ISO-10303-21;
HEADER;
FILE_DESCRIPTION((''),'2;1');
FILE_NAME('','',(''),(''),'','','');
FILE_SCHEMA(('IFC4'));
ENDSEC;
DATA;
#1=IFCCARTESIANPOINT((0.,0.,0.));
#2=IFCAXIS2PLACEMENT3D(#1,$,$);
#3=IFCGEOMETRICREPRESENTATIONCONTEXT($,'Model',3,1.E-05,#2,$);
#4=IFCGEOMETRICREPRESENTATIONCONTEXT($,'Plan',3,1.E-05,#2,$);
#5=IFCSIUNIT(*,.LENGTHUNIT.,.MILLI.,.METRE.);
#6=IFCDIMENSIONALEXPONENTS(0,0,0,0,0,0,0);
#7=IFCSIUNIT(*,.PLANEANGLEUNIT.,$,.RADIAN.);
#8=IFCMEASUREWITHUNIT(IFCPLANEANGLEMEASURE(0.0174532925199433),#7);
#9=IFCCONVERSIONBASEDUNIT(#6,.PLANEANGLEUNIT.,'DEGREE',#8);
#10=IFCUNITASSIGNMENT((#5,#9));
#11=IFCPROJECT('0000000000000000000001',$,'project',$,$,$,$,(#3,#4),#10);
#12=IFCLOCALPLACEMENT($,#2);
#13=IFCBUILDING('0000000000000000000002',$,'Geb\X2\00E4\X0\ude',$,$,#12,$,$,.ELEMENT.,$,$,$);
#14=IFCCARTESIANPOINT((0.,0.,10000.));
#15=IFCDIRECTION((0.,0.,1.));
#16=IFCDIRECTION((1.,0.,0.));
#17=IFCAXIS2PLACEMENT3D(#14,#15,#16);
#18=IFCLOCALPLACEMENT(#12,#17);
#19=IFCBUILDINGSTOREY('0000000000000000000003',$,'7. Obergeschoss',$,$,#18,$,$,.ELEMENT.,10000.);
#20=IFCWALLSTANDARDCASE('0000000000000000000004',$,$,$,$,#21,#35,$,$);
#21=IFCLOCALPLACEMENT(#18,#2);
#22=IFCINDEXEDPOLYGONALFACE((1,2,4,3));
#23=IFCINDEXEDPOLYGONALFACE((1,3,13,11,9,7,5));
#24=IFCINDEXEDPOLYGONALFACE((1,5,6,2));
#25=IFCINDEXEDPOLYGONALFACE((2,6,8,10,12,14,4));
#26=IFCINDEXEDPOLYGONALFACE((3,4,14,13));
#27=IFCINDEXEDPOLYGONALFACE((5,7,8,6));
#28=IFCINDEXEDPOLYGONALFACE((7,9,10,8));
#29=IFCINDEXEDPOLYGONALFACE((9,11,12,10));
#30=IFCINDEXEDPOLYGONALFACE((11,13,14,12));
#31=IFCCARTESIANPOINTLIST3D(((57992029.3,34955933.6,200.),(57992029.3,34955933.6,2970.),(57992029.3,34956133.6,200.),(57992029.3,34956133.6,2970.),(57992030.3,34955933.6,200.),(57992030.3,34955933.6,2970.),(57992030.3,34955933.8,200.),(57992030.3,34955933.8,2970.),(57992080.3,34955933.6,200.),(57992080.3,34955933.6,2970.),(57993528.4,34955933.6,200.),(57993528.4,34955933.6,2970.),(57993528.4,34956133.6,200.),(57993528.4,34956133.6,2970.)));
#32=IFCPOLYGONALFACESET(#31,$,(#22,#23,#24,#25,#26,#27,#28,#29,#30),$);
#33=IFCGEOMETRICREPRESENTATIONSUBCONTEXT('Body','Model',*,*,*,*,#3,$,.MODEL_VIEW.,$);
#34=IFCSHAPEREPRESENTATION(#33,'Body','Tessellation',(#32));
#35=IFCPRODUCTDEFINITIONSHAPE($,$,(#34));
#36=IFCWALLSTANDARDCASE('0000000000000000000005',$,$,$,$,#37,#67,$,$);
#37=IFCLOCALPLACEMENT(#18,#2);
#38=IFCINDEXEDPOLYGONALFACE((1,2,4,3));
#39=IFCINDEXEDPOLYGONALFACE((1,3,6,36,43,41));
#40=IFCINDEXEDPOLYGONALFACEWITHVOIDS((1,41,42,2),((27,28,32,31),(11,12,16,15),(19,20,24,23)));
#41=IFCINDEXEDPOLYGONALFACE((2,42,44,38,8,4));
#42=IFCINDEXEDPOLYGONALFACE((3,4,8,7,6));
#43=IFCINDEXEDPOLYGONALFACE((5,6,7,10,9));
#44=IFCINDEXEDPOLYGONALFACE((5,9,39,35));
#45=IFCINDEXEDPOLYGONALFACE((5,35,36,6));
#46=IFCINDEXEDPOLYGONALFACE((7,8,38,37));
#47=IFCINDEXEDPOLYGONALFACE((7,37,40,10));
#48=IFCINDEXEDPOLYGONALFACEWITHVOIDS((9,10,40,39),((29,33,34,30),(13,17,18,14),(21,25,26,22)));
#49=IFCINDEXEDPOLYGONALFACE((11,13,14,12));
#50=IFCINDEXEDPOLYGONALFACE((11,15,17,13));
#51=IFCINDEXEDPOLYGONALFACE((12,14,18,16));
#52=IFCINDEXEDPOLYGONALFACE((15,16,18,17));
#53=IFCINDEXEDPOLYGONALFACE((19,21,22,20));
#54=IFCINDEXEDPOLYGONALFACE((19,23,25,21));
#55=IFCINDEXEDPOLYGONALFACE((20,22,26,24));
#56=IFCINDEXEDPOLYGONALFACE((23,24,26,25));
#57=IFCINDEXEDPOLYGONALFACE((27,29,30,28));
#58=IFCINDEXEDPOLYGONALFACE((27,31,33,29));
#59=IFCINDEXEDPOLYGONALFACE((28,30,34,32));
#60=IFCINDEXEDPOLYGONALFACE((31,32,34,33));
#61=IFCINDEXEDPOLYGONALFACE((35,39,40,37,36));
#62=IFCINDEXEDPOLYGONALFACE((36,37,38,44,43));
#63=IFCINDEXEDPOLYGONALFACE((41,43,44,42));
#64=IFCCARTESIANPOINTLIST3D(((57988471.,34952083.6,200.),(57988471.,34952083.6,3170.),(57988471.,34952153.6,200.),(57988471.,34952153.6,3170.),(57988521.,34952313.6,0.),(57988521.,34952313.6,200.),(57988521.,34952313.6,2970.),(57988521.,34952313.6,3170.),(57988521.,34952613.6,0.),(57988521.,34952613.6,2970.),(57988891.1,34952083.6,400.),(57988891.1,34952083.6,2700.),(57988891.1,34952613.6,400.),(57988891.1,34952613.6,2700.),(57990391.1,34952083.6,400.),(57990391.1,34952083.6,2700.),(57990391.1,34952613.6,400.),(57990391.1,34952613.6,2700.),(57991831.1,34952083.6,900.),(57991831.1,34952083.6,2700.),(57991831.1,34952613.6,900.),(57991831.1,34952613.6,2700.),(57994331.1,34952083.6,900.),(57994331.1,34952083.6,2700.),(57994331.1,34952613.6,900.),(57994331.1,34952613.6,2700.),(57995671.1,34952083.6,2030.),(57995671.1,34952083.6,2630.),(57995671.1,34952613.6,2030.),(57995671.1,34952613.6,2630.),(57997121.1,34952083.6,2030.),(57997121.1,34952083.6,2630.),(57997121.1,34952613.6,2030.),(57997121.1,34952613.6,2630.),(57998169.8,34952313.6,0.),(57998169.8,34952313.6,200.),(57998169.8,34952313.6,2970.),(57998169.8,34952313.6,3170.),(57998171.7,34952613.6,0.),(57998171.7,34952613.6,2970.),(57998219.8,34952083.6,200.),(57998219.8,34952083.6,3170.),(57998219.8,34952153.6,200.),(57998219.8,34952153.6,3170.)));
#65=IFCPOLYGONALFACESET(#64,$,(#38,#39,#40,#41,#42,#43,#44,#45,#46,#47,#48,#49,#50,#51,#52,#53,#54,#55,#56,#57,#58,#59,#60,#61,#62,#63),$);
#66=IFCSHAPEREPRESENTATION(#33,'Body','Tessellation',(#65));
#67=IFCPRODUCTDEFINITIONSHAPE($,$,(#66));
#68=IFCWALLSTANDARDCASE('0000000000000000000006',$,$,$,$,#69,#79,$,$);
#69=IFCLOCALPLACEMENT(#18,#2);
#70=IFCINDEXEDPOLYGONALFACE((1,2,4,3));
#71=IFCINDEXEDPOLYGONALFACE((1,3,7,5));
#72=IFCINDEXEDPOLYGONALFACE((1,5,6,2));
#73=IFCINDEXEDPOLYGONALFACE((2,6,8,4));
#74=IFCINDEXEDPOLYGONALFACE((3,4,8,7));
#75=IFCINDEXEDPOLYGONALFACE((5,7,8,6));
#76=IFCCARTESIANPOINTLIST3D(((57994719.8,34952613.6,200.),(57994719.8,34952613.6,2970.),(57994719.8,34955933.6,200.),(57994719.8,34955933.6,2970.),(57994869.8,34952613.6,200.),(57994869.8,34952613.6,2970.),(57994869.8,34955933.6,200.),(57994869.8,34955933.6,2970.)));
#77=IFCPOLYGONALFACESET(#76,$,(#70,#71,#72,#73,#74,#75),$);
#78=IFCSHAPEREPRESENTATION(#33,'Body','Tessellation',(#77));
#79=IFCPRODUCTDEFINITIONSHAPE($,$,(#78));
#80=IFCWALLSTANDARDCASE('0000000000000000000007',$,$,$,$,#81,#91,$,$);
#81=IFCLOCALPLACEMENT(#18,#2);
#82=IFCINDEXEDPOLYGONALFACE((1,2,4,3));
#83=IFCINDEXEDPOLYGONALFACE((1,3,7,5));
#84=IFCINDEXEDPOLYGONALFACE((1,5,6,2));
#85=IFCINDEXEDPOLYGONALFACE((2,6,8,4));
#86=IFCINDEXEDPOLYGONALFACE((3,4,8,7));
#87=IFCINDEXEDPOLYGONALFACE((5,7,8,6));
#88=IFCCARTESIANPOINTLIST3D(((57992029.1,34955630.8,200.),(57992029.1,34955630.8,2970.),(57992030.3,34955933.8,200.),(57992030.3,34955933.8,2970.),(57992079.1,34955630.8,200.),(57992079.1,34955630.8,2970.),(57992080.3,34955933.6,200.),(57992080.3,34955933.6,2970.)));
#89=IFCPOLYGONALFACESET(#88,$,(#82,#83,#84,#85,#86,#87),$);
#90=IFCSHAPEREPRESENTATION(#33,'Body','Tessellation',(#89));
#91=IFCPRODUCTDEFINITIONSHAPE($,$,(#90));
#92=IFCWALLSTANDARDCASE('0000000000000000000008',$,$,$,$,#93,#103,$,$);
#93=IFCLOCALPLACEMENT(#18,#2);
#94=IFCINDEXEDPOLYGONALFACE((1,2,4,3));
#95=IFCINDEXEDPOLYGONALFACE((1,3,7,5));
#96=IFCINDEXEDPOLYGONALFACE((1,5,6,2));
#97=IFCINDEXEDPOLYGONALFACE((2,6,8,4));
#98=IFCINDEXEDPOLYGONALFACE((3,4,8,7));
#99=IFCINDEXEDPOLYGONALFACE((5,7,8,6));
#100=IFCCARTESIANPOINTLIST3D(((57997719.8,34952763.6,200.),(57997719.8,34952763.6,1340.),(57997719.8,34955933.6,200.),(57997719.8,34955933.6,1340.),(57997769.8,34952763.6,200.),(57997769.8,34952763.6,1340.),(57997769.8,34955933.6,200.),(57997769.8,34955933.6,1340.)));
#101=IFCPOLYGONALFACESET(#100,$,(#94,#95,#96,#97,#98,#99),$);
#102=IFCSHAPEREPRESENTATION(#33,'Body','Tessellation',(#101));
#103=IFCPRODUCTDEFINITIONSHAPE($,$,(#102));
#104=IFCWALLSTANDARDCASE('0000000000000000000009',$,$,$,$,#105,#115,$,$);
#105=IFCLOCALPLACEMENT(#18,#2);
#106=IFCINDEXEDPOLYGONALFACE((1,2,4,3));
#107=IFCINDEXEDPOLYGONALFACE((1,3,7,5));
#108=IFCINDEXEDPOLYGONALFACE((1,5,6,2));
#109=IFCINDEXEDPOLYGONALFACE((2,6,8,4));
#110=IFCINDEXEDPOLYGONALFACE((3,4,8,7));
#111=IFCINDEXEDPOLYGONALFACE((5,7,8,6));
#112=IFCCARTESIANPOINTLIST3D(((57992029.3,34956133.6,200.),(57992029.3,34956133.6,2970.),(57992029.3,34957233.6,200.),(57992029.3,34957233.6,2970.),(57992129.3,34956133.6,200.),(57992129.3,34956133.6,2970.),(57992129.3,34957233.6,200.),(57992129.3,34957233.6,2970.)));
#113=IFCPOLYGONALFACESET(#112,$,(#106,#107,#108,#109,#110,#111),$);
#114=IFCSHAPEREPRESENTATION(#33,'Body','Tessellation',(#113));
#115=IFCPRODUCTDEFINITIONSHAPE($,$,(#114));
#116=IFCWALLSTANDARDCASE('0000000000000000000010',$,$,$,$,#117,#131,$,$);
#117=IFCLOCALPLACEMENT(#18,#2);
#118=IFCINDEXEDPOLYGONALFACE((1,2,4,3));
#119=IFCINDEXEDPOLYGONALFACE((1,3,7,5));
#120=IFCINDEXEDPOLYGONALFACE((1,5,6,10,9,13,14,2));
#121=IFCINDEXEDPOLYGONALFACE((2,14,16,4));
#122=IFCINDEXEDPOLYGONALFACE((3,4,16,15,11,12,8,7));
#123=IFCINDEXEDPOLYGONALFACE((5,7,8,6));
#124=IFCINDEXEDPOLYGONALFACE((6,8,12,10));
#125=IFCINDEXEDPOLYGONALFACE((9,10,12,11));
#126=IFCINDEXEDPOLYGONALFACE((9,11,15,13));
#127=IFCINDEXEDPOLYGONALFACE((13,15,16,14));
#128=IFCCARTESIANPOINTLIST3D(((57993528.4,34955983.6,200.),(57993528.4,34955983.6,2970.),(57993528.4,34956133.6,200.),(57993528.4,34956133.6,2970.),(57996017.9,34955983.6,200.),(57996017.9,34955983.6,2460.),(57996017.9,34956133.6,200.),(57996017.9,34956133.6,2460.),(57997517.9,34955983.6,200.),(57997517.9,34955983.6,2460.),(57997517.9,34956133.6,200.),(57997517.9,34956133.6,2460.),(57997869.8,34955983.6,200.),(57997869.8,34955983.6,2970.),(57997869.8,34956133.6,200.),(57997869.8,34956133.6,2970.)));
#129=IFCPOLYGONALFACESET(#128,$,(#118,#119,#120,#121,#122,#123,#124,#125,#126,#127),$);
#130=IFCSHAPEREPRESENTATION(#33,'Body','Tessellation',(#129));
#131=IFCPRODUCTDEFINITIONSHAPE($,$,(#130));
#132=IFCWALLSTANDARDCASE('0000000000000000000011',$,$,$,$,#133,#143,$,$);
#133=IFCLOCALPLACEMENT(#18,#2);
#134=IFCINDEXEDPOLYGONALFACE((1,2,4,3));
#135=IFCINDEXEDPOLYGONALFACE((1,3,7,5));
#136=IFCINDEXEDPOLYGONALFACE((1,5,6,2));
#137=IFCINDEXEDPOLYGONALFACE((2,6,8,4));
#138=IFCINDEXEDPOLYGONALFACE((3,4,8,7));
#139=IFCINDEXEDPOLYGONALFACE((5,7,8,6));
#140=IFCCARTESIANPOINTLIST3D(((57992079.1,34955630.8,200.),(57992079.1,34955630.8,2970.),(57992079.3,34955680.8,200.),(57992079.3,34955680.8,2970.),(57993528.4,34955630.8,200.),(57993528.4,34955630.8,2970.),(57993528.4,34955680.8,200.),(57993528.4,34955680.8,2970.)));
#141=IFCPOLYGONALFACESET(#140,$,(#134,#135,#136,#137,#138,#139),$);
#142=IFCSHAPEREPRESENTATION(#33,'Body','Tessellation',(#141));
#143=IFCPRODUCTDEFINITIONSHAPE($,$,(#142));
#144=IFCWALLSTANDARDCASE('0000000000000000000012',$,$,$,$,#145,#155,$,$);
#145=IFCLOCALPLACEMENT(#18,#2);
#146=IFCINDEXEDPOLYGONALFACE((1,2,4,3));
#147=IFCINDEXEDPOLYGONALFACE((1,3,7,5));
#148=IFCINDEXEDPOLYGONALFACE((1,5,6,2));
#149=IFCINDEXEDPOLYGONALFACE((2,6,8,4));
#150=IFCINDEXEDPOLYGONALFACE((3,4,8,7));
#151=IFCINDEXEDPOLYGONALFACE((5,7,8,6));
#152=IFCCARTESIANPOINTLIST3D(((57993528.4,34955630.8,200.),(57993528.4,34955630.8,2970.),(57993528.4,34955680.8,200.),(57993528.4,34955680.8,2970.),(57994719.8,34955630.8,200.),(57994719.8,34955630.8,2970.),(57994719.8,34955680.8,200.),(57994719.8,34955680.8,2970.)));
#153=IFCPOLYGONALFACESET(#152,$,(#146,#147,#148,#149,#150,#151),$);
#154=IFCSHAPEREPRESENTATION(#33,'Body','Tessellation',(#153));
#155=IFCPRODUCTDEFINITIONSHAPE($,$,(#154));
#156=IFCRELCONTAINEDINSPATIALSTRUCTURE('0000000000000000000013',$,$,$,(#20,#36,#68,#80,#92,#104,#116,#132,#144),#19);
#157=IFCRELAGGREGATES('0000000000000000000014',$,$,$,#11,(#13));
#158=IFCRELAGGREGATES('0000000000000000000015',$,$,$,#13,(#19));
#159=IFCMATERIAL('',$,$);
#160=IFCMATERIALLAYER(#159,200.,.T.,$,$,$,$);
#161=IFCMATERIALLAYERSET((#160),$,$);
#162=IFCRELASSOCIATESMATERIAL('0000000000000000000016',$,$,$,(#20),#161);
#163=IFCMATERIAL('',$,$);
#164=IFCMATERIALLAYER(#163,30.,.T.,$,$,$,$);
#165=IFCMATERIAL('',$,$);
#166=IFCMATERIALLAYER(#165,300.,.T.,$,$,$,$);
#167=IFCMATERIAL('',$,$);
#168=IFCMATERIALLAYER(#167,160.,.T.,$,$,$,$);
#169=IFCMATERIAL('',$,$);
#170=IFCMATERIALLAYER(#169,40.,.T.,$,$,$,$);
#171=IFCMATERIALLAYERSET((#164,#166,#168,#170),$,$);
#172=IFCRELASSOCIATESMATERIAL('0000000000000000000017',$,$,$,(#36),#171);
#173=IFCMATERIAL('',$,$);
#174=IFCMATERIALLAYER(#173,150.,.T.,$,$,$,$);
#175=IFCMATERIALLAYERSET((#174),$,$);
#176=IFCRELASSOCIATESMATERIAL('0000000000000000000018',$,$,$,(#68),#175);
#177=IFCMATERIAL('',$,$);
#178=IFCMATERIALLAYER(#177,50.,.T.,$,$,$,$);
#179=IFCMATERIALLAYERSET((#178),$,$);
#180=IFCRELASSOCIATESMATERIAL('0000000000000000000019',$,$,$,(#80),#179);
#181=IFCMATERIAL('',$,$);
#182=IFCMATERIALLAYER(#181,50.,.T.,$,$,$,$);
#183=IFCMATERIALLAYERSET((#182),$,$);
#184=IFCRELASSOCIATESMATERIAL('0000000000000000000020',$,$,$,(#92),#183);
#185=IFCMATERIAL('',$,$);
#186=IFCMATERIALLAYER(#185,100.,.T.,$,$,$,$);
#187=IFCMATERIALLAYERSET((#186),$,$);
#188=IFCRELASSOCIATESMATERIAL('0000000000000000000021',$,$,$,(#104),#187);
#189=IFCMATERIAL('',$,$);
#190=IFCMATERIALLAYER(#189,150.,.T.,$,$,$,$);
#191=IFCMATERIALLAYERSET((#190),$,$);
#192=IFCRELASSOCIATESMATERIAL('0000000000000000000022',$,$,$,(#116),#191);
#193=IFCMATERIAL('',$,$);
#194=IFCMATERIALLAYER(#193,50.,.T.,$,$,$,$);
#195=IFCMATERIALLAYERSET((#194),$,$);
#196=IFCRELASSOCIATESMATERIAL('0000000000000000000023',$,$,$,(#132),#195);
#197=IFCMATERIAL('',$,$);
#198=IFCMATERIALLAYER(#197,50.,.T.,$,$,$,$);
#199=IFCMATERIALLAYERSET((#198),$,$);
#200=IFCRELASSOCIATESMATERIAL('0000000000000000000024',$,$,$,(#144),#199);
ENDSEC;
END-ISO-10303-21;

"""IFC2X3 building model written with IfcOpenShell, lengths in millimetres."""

from ifc_helpers import new_model, entity, si_unit, converted_unit, frame, frame_2d, origin, origin_with_axes, place, context, subcontext, project, spatial, polyline, rectangle, outline, extrude, clip, bounded_halfspace, material, layer, layer_set, layer_usage, element, save


model = new_model("IFC2X3")

# Units and contexts
model_context = context("Model", 3, precision=1e-05, world=origin())
plan_context = context("Plan", 3, precision=1e-05, world=origin())
body_context = subcontext(model_context, "Body", "Model", "MODEL_VIEW")
ifc_project = project(units=[si_unit("LENGTHUNIT", "METRE", prefix="MILLI"), converted_unit("PLANEANGLEUNIT", "DEGREE", entity("IfcPlaneAngleMeasure", 0.0174532925199433), si_unit("PLANEANGLEUNIT", "RADIAN"), dimensions=[0, 0, 0, 0, 0, 0, 0])], contexts=[model_context, plan_context])

# Building, storey
building_placement = place(None, origin())
building = spatial("IfcBuilding", under=ifc_project, at=building_placement, Name="Gebäude", CompositionType="ELEMENT")
storey_placement = place(building_placement, frame((0.0, 0.0, 10000.0), z_axis=(0.0, 0.0, 1.0), x_axis=(1.0, 0.0, 0.0)))
storey = spatial("IfcBuildingStorey", under=building, at=storey_placement, Name="7. Obergeschoss", CompositionType="ELEMENT", Elevation=10000.0)

# Wall
ifc_material_1 = material(Name="")
ifc_layer_1 = layer(ifc_material_1, 200.0, ventilated=True)
ifc_layer_set_1 = layer_set([ifc_layer_1])
ifc_layer_usage_1 = layer_usage(ifc_layer_set_1, "AXIS2", "POSITIVE", 0.0)
wall_1_placement = place(storey_placement, frame((57993528.4, 34956133.6, 200.0), z_axis=(0.0, 0.0, 1.0), x_axis=(-1.0, 0.0, 0.0)))
element("IfcWallStandardCase", 1, at=wall_1_placement, inside=storey, material=ifc_layer_usage_1, context=body_context, shape_type="SweptSolid", body=[
    extrude(outline(polyline([(0.0, 0.0), (1499.1, 0.0), (1499.1, 200.0), (1498.1, 200.0), (1498.1, 199.8), (1448.1, 200.0), (0.0, 200.0), (0.0, 0.0)])), origin_with_axes(), (0.0, 0.0, 1.0), 2770.0),
])

# Wall, openings
ifc_material_2 = material(Name="")
ifc_layer_2 = layer(ifc_material_2, 30.0, ventilated=True)
ifc_material_3 = material(Name="")
ifc_layer_3 = layer(ifc_material_3, 300.0, ventilated=True)
ifc_material_4 = material(Name="")
ifc_layer_4 = layer(ifc_material_4, 160.0, ventilated=True)
ifc_material_5 = material(Name="")
ifc_layer_5 = layer(ifc_material_5, 40.0, ventilated=True)
ifc_layer_set_2 = layer_set([ifc_layer_2, ifc_layer_3, ifc_layer_4, ifc_layer_5])
ifc_layer_usage_2 = layer_usage(ifc_layer_set_2, "AXIS2", "POSITIVE", 0.0)
wall_2_placement = place(storey_placement, frame((57998171.7, 34952613.6, 0.0), z_axis=(0.0, 0.0, 1.0), x_axis=(-1.0, 0.0, 0.0)))
wall_2 = element("IfcWallStandardCase", 2, at=wall_2_placement, inside=storey, material=ifc_layer_usage_2, context=body_context, shape_type="Clipping", body=[
    clip(clip(clip(clip(extrude(outline(polyline([(0.0, 0.0), (9650.7, 0.0), (9650.7, 300.0), (9700.7, 460.0), (9700.7, 530.0), (-48.1, 530.0), (-48.1, 460.0), (1.9, 300.0), (0.0, 0.0)])), origin_with_axes(), (0.0, 0.0, 1.0), 3170.0), bounded_halfspace(frame((1.9, 300.0, 0.0), z_axis=(0.0, 0.0, 1.0), x_axis=(1.0, 0.0, 0.0)), True, origin(), polyline([(1.9, 300.0), (0.0, 0.0), (9650.7, 0.0), (9650.7, 300.0), (1.9, 300.0)]))), bounded_halfspace(frame((0.0, 0.0, 2970.0), z_axis=(0.0, 0.0, -1.0), x_axis=(1.0, 0.0, 0.0)), True, origin(), polyline([(0.0, 0.0), (9650.7, 0.0), (9650.7, 300.0), (1.9, 300.0), (0.0, 0.0)]))), bounded_halfspace(frame((-48.1, 460.0, 200.0), z_axis=(0.0, 0.0, 1.0), x_axis=(1.0, 0.0, 0.0)), True, origin(), polyline([(-48.1, 460.0), (1.9, 300.0), (9650.7, 300.0), (9700.7, 460.0), (9700.7, 530.0), (-48.1, 530.0), (-48.1, 460.0)]))), bounded_halfspace(frame((1.9, 300.0, 3170.0), z_axis=(0.0, 0.0, -1.0), x_axis=(1.0, 0.0, 0.0)), True, origin(), polyline([(1.9, 300.0), (9650.7, 300.0), (9700.7, 460.0), (9700.7, 530.0), (-48.1, 530.0), (-48.1, 460.0), (1.9, 300.0)]))),
])
opening_1_placement = place(wall_2_placement, frame((3840.6, 0.0, 900.0), z_axis=(0.0, 1.0, 0.0), x_axis=(0.0, 0.0, 1.0)))
element("IfcOpeningElement", 3, at=opening_1_placement, cuts=wall_2, ObjectType="Opening", context=body_context, shape_type="SweptSolid", body=[
    extrude(rectangle(XDim=1800.0, YDim=2500.0, at=frame_2d((900.0, 1250.0), x_axis=(1.0, 0.0))), origin_with_axes(), (0.0, 0.0, 1.0), 530.0),
])
opening_2_placement = place(wall_2_placement, frame((7780.6, 0.0, 400.0), z_axis=(0.0, 1.0, 0.0), x_axis=(0.0, 0.0, 1.0)))
element("IfcOpeningElement", 4, at=opening_2_placement, cuts=wall_2, ObjectType="Opening", context=body_context, shape_type="SweptSolid", body=[
    extrude(rectangle(XDim=2300.0, YDim=1500.0, at=frame_2d((1150.0, 750.0), x_axis=(1.0, 0.0))), origin_with_axes(), (0.0, 0.0, 1.0), 530.0),
])
opening_3_placement = place(wall_2_placement, frame((1050.6, 0.0, 2030.0), z_axis=(0.0, 1.0, 0.0), x_axis=(0.0, 0.0, 1.0)))
element("IfcOpeningElement", 5, at=opening_3_placement, cuts=wall_2, ObjectType="Opening", context=body_context, shape_type="SweptSolid", body=[
    extrude(rectangle(XDim=600.0, YDim=1450.0, at=frame_2d((300.0, 725.0), x_axis=(1.0, 0.0))), origin_with_axes(), (0.0, 0.0, 1.0), 530.0),
])

# Walls
ifc_material_6 = material(Name="")
ifc_layer_6 = layer(ifc_material_6, 150.0, ventilated=True)
ifc_layer_set_3 = layer_set([ifc_layer_6])
ifc_layer_usage_3 = layer_usage(ifc_layer_set_3, "AXIS2", "POSITIVE", 0.0)
wall_3_placement = place(storey_placement, frame((57994869.8, 34952613.6, 200.0), z_axis=(0.0, 0.0, 1.0), x_axis=(0.0, 1.0, 0.0)))
element("IfcWallStandardCase", 6, at=wall_3_placement, inside=storey, material=ifc_layer_usage_3, context=body_context, shape_type="SweptSolid", body=[
    extrude(rectangle(XDim=3319.9, YDim=150.0, at=frame_2d((1660.0, 75.0), x_axis=(1.0, 0.0))), origin_with_axes(), (0.0, 0.0, 1.0), 2770.0),
])
ifc_material_7 = material(Name="")
ifc_layer_7 = layer(ifc_material_7, 50.0, ventilated=True)
ifc_layer_set_4 = layer_set([ifc_layer_7])
ifc_layer_usage_4 = layer_usage(ifc_layer_set_4, "AXIS2", "POSITIVE", 0.0)
wall_4_placement = place(storey_placement, frame((57992079.1, 34955630.8, 200.0), z_axis=(0.0, 0.0, 1.0), x_axis=(0.003955, 0.999992, 0.0)))
element("IfcWallStandardCase", 7, at=wall_4_placement, inside=storey, material=ifc_layer_usage_4, context=body_context, shape_type="SweptSolid", body=[
    extrude(outline(polyline([(0.0, 0.0), (302.8, 0.0), (302.8, 50.0), (-0.2, 50.0), (0.0, 0.0)])), origin_with_axes(), (0.0, 0.0, 1.0), 2770.0),
])
ifc_material_8 = material(Name="")
ifc_layer_8 = layer(ifc_material_8, 50.0, ventilated=True)
ifc_layer_set_5 = layer_set([ifc_layer_8])
ifc_layer_usage_5 = layer_usage(ifc_layer_set_5, "AXIS2", "POSITIVE", 0.0)
wall_5_placement = place(storey_placement, frame((57997719.8, 34955933.6, 200.0), z_axis=(0.0, 0.0, 1.0), x_axis=(0.0, -1.0, 0.0)))
element("IfcWallStandardCase", 8, at=wall_5_placement, inside=storey, material=ifc_layer_usage_5, context=body_context, shape_type="SweptSolid", body=[
    extrude(rectangle(XDim=3169.9, YDim=50.0, at=frame_2d((1585.0, 25.0), x_axis=(1.0, 0.0))), origin_with_axes(), (0.0, 0.0, 1.0), 1140.0),
])
ifc_material_9 = material(Name="")
ifc_layer_9 = layer(ifc_material_9, 100.0, ventilated=True)
ifc_layer_set_6 = layer_set([ifc_layer_9])
ifc_layer_usage_6 = layer_usage(ifc_layer_set_6, "AXIS2", "POSITIVE", 0.0)
wall_6_placement = place(storey_placement, frame((57992129.3, 34956133.6, 200.0), z_axis=(0.0, 0.0, 1.0), x_axis=(0.0, 1.0, 0.0)))
element("IfcWallStandardCase", 9, at=wall_6_placement, inside=storey, material=ifc_layer_usage_6, context=body_context, shape_type="SweptSolid", body=[
    extrude(outline(polyline([(0.0, 0.0), (1100.0, 0.0), (1100.0, 100.0), (0.0, 100.0), (0.0, 0.0)])), origin_with_axes(), (0.0, 0.0, 1.0), 2770.0),
])

# Wall, opening
ifc_material_10 = material(Name="")
ifc_layer_10 = layer(ifc_material_10, 150.0, ventilated=True)
ifc_layer_set_7 = layer_set([ifc_layer_10])
ifc_layer_usage_7 = layer_usage(ifc_layer_set_7, "AXIS2", "POSITIVE", 0.0)
wall_7_placement = place(storey_placement, frame((57997869.8, 34956133.6, 200.0), z_axis=(0.0, 0.0, 1.0), x_axis=(-1.0, 0.0, 0.0)))
wall_7 = element("IfcWallStandardCase", 10, at=wall_7_placement, inside=storey, material=ifc_layer_usage_7, context=body_context, shape_type="SweptSolid", body=[
    extrude(rectangle(XDim=4341.4, YDim=150.0, at=frame_2d((2170.7, 75.0), x_axis=(1.0, 0.0))), origin_with_axes(), (0.0, 0.0, 1.0), 2770.0),
])
opening_4_placement = place(wall_7_placement, frame((351.9, 0.0, 0.0), z_axis=(0.0, 1.0, 0.0), x_axis=(0.0, 0.0, 1.0)))
element("IfcOpeningElement", 11, at=opening_4_placement, cuts=wall_7, ObjectType="Opening", context=body_context, shape_type="SweptSolid", body=[
    extrude(rectangle(XDim=2260.0, YDim=1500.0, at=frame_2d((1130.0, 750.0), x_axis=(1.0, 0.0))), origin_with_axes(), (0.0, 0.0, 1.0), 150.0),
])

# Walls
ifc_material_11 = material(Name="")
ifc_layer_11 = layer(ifc_material_11, 50.0, ventilated=True)
ifc_layer_set_8 = layer_set([ifc_layer_11])
ifc_layer_usage_8 = layer_usage(ifc_layer_set_8, "AXIS2", "POSITIVE", 0.0)
wall_8_placement = place(storey_placement, frame((57993528.4, 34955680.8, 200.0), z_axis=(0.0, 0.0, 1.0), x_axis=(-1.0, 0.0, 0.0)))
element("IfcWallStandardCase", 12, at=wall_8_placement, inside=storey, material=ifc_layer_usage_8, context=body_context, shape_type="SweptSolid", body=[
    extrude(outline(polyline([(0.0, 0.0), (1449.1, 0.0), (1449.3, 50.0), (0.0, 50.0), (0.0, 0.0)])), origin_with_axes(), (0.0, 0.0, 1.0), 2770.0),
])
ifc_material_12 = material(Name="")
ifc_layer_12 = layer(ifc_material_12, 50.0, ventilated=True)
ifc_layer_set_9 = layer_set([ifc_layer_12])
ifc_layer_usage_9 = layer_usage(ifc_layer_set_9, "AXIS2", "POSITIVE", 0.0)
wall_9_placement = place(storey_placement, frame((57994719.8, 34955680.8, 200.0), z_axis=(0.0, 0.0, 1.0), x_axis=(-1.0, 0.0, 0.0)))
element("IfcWallStandardCase", 13, at=wall_9_placement, inside=storey, material=ifc_layer_usage_9, context=body_context, shape_type="SweptSolid", body=[
    extrude(outline(polyline([(0.0, 0.0), (1191.4, 0.0), (1191.4, 50.0), (0.0, 50.0), (0.0, 0.0)])), origin_with_axes(), (0.0, 0.0, 1.0), 2770.0),
])

save(model, "model.ifc")
